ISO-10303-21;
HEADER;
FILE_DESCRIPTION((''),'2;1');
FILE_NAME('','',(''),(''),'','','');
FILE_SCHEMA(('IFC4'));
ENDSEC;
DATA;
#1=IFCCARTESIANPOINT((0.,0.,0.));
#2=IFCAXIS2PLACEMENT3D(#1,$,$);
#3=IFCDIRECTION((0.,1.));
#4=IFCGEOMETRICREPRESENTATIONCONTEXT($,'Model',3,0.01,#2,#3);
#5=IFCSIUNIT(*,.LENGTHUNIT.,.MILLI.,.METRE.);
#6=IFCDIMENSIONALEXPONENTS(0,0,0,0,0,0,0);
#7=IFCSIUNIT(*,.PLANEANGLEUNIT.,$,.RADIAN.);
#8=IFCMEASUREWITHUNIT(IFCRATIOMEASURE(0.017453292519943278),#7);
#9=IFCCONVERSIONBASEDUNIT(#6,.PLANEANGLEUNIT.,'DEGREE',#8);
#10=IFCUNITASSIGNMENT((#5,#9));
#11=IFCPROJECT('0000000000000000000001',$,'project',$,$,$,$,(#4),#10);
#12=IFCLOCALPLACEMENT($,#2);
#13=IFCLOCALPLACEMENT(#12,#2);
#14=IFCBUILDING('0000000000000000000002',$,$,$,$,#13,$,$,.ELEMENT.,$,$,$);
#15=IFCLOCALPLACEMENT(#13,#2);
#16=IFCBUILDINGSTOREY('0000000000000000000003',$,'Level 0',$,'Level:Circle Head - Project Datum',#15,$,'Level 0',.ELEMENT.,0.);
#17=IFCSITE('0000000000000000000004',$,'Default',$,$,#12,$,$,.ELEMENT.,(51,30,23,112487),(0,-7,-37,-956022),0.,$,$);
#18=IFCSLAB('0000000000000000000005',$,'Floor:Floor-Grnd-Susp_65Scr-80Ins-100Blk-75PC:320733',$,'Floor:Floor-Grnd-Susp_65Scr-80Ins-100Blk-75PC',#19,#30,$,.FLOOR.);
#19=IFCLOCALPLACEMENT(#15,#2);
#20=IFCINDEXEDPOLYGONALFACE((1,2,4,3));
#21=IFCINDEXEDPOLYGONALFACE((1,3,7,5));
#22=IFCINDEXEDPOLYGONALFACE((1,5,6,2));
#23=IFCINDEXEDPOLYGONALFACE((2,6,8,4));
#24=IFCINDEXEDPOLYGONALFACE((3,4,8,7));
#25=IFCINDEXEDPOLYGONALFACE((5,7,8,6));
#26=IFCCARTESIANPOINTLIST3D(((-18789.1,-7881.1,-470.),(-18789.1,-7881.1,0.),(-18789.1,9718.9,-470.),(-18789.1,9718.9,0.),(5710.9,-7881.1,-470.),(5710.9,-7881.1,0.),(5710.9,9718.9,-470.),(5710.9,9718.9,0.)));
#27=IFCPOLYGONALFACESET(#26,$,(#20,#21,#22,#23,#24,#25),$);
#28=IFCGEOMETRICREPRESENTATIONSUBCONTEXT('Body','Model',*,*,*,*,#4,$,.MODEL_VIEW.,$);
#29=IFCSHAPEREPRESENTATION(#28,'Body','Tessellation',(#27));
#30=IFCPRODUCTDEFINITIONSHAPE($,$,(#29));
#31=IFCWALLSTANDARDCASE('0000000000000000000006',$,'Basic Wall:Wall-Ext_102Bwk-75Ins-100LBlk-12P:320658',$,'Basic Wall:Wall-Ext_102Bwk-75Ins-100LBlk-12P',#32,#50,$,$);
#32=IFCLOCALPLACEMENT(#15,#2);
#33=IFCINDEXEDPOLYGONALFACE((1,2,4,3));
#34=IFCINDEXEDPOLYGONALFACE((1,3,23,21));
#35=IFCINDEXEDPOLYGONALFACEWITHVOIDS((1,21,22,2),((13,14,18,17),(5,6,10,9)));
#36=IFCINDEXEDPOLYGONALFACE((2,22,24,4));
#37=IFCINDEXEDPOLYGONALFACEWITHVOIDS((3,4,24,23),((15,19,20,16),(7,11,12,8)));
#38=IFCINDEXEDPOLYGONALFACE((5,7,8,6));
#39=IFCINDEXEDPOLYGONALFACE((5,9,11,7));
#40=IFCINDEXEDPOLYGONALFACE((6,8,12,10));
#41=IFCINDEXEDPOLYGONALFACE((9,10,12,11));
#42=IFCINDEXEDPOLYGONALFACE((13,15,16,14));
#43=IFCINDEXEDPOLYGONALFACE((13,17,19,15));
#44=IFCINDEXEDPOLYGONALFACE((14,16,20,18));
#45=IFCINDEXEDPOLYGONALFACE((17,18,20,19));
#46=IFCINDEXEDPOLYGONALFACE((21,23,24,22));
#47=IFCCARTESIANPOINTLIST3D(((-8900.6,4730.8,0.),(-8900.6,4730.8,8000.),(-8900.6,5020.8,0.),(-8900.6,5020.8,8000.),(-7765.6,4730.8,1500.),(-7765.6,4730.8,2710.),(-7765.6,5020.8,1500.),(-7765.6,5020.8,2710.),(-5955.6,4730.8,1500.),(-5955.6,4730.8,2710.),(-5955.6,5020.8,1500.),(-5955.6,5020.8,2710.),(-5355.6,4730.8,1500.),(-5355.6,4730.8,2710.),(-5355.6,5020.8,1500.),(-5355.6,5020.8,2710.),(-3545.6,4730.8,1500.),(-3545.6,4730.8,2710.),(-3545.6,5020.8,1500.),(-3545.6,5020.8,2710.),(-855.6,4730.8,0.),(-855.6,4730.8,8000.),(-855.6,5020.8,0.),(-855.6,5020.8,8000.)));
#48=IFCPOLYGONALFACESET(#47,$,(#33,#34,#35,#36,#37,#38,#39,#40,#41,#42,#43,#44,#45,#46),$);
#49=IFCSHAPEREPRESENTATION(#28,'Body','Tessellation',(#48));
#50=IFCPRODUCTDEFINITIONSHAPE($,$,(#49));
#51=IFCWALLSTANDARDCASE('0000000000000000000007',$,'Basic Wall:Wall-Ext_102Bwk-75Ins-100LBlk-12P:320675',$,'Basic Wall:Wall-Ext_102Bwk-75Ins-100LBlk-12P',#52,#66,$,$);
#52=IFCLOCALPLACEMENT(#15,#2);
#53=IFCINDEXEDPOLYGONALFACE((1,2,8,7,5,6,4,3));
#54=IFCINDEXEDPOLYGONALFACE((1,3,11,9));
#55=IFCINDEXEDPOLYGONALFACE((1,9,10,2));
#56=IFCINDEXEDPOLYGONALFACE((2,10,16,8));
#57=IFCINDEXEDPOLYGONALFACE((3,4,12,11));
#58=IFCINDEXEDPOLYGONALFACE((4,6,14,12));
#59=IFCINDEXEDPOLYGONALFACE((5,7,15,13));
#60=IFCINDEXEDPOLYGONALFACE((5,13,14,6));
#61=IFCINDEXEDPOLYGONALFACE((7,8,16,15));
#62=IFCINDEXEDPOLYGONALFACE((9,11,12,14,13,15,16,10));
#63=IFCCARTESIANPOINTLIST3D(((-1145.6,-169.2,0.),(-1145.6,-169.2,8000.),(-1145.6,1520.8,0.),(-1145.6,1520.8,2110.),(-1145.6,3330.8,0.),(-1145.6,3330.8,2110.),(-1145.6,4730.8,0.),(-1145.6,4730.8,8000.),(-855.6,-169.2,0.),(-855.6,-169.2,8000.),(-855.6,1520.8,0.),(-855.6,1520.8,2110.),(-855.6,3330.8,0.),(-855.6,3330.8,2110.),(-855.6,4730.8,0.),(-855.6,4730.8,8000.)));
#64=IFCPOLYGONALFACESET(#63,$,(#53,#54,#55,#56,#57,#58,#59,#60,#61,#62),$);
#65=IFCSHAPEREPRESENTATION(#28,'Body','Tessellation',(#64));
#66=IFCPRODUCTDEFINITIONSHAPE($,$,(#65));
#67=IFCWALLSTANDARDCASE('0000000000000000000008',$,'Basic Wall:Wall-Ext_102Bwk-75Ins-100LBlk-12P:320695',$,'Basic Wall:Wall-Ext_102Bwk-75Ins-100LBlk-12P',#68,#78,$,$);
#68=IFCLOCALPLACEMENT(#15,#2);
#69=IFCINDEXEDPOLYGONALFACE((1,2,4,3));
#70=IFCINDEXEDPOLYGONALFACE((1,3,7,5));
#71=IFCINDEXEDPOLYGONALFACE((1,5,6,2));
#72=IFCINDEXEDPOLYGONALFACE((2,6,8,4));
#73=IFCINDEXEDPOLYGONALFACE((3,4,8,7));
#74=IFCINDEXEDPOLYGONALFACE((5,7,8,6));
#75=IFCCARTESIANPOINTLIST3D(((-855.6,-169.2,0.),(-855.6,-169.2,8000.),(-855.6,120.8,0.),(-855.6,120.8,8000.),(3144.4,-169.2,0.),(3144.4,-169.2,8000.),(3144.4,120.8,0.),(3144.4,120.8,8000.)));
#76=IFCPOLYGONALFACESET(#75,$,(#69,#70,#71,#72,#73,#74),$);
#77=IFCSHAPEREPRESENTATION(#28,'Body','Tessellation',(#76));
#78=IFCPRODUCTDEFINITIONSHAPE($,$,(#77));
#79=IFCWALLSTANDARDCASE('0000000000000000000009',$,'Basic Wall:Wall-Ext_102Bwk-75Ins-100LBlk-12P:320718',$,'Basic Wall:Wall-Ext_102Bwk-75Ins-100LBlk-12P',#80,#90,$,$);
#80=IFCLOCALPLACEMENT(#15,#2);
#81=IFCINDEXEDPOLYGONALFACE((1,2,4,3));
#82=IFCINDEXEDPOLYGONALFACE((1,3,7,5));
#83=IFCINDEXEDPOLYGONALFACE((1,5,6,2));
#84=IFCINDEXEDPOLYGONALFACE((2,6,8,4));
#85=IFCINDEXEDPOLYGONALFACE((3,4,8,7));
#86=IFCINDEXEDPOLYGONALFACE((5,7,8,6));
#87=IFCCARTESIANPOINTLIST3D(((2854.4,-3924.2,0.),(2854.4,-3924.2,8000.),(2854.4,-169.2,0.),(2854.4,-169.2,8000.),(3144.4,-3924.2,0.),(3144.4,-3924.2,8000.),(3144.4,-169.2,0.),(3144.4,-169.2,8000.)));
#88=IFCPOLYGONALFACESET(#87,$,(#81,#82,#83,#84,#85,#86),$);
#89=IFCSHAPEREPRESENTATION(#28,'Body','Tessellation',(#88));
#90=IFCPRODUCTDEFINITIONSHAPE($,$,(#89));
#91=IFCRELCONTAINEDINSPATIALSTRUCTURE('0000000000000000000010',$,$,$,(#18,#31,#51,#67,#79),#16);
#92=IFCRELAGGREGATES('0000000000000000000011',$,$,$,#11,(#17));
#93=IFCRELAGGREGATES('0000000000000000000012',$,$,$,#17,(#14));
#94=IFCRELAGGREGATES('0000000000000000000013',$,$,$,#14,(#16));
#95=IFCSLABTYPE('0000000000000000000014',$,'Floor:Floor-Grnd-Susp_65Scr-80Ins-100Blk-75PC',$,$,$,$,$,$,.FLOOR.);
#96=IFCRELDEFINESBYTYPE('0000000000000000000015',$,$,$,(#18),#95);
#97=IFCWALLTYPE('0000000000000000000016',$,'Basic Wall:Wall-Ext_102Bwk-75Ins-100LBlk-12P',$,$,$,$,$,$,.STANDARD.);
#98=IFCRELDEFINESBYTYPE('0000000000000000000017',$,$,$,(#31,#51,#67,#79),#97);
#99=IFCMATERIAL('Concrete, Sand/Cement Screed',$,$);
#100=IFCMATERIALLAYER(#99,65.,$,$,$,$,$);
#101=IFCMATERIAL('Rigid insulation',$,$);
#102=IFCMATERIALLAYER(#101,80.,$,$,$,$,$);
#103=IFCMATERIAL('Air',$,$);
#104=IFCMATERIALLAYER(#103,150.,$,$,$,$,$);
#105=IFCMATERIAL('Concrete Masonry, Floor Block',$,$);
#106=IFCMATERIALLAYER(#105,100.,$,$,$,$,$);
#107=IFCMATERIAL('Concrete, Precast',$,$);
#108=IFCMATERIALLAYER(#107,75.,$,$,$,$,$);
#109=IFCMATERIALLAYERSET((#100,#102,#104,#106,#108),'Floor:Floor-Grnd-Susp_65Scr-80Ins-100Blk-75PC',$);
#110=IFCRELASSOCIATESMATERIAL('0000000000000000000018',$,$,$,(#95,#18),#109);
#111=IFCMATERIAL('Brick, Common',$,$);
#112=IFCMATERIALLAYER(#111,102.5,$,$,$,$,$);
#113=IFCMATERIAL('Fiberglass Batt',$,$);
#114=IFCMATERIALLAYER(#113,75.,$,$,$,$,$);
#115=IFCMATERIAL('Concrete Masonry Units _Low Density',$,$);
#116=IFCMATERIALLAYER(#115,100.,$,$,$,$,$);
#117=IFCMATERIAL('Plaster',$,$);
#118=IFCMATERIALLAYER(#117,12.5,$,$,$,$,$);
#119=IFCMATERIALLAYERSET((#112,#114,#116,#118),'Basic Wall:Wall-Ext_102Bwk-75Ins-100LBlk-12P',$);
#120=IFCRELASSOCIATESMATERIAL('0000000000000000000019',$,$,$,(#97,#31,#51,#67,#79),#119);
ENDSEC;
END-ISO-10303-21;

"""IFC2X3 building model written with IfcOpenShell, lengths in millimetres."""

from ifc_helpers import new_model, entity, si_unit, converted_unit, direction, frame, frame_2d, origin, origin_2d_with_axis, place, context, subcontext, project, spatial, rectangle, extrude, material, layer, layer_set, layer_usage, type_object, element, save


model = new_model("IFC2X3")

# Units and contexts
model_context = context("Model", 3, precision=0.01, world=origin(), true_north=direction((0.0, 1.0)))
body_context = subcontext(model_context, "Body", "Model", "MODEL_VIEW")
ifc_project = project(units=[si_unit("LENGTHUNIT", "METRE", prefix="MILLI"), converted_unit("PLANEANGLEUNIT", "DEGREE", entity("IfcRatioMeasure", 0.017453292519943278), si_unit("PLANEANGLEUNIT", "RADIAN"), dimensions=[0, 0, 0, 0, 0, 0, 0])], contexts=[model_context])

# Site, building, storey
site_placement = place(None, origin())
site = spatial("IfcSite", under=ifc_project, at=site_placement, Name="Default", CompositionType="ELEMENT", RefLatitude=(51, 30, 23, 112487), RefLongitude=(0, -7, -37, -956022), RefElevation=0.0)
building_placement = place(site_placement, origin())
building = spatial("IfcBuilding", under=site, at=building_placement, CompositionType="ELEMENT")
storey_placement = place(building_placement, origin())
storey = spatial("IfcBuildingStorey", under=building, at=storey_placement, Name="Level 0", ObjectType="Level:Circle Head - Project Datum", LongName="Level 0", CompositionType="ELEMENT", Elevation=0.0)

# Slab
ifc_material_1 = material(Name="Concrete, Sand/Cement Screed")
ifc_layer_1 = layer(ifc_material_1, 65.0)
ifc_material_2 = material(Name="Rigid insulation")
ifc_layer_2 = layer(ifc_material_2, 80.0)
ifc_material_3 = material(Name="Air")
ifc_layer_3 = layer(ifc_material_3, 150.0)
ifc_material_4 = material(Name="Concrete Masonry, Floor Block")
ifc_layer_4 = layer(ifc_material_4, 100.0)
ifc_material_5 = material(Name="Concrete, Precast")
ifc_layer_5 = layer(ifc_material_5, 75.0)
ifc_layer_set_1 = layer_set([ifc_layer_1, ifc_layer_2, ifc_layer_3, ifc_layer_4, ifc_layer_5], Name="Floor:Floor-Grnd-Susp_65Scr-80Ins-100Blk-75PC")
ifc_layer_usage_1 = layer_usage(ifc_layer_set_1, "AXIS3", "POSITIVE", 0.0)
slab_type = type_object("IfcSlabType", Name="Floor:Floor-Grnd-Susp_65Scr-80Ins-100Blk-75PC", PredefinedType="FLOOR", material=ifc_layer_set_1)
slab_placement = place(storey_placement, origin())
element("IfcSlab", 1, at=slab_placement, inside=storey, type_object=slab_type, material=ifc_layer_usage_1, Name="Floor:Floor-Grnd-Susp_65Scr-80Ins-100Blk-75PC:320733", ObjectType="Floor:Floor-Grnd-Susp_65Scr-80Ins-100Blk-75PC", PredefinedType="FLOOR", context=body_context, shape_type="SweptSolid", body=[
    extrude(rectangle(XDim=17600.0, YDim=24500.0, at=origin_2d_with_axis()), frame((-6539.1, 918.9, 0.0), z_axis=(0.0, 0.0, -1.0), x_axis=(0.0, 1.0, 0.0)), (0.0, 0.0, 1.0), 470.0),
])

# Wall, openings
ifc_material_6 = material(Name="Brick, Common")
ifc_layer_6 = layer(ifc_material_6, 102.5)
ifc_material_7 = material(Name="Fiberglass Batt")
ifc_layer_7 = layer(ifc_material_7, 75.0)
ifc_material_8 = material(Name="Concrete Masonry Units _Low Density")
ifc_layer_8 = layer(ifc_material_8, 100.0)
ifc_material_9 = material(Name="Plaster")
ifc_layer_9 = layer(ifc_material_9, 12.5)
ifc_layer_set_2 = layer_set([ifc_layer_6, ifc_layer_7, ifc_layer_8, ifc_layer_9], Name="Basic Wall:Wall-Ext_102Bwk-75Ins-100LBlk-12P")
ifc_layer_usage_2 = layer_usage(ifc_layer_set_2, "AXIS2", "NEGATIVE", 145.0)
wall_type = type_object("IfcWallType", Name="Basic Wall:Wall-Ext_102Bwk-75Ins-100LBlk-12P", PredefinedType="STANDARD", material=ifc_layer_set_2)
wall_1_placement = place(storey_placement, frame((-8900.6, 4875.8, 0.0)))
wall_1 = element("IfcWallStandardCase", 2, at=wall_1_placement, inside=storey, type_object=wall_type, material=ifc_layer_usage_2, Name="Basic Wall:Wall-Ext_102Bwk-75Ins-100LBlk-12P:320658", ObjectType="Basic Wall:Wall-Ext_102Bwk-75Ins-100LBlk-12P", context=body_context, shape_type="SweptSolid", body=[
    extrude(rectangle(XDim=8045.0, YDim=290.0, at=frame_2d((4022.5, 0.0), x_axis=(-1.0, 0.0))), origin(), (0.0, 0.0, 1.0), 8000.0),
])
opening_1_placement = place(wall_1_placement, frame((3545.0, -145.0, 1500.0)))
element("IfcOpeningElement", 3, at=opening_1_placement, cuts=wall_1, ObjectType="Opening", context=body_context, shape_type="SweptSolid", body=[
    extrude(rectangle(XDim=1210.0, YDim=1810.0, at=frame_2d((605.0, 905.0), x_axis=(-1.0, 0.0))), frame((0.0, 0.0, 0.0), z_axis=(0.0, 1.0, 0.0), x_axis=(0.0, 0.0, 1.0)), (0.0, 0.0, 1.0), 290.0),
])
opening_2_placement = place(wall_1_placement, frame((1135.0, -145.0, 1500.0)))
element("IfcOpeningElement", 4, at=opening_2_placement, cuts=wall_1, ObjectType="Opening", context=body_context, shape_type="SweptSolid", body=[
    extrude(rectangle(XDim=1210.0, YDim=1810.0, at=frame_2d((605.0, 905.0), x_axis=(-1.0, 0.0))), frame((0.0, 0.0, 0.0), z_axis=(0.0, 1.0, 0.0), x_axis=(0.0, 0.0, 1.0)), (0.0, 0.0, 1.0), 290.0),
])

# Wall, opening
ifc_layer_usage_3 = layer_usage(ifc_layer_set_2, "AXIS2", "NEGATIVE", 145.0)
wall_2_placement = place(storey_placement, frame((-1000.6, 4730.8, 0.0), z_axis=(0.0, 0.0, 1.0), x_axis=(0.0, -1.0, 0.0)))
wall_2 = element("IfcWallStandardCase", 5, at=wall_2_placement, inside=storey, type_object=wall_type, material=ifc_layer_usage_3, Name="Basic Wall:Wall-Ext_102Bwk-75Ins-100LBlk-12P:320675", ObjectType="Basic Wall:Wall-Ext_102Bwk-75Ins-100LBlk-12P", context=body_context, shape_type="SweptSolid", body=[
    extrude(rectangle(XDim=4900.0, YDim=290.0, at=frame_2d((2450.0, 0.0), x_axis=(1.0, 0.0))), origin(), (0.0, 0.0, 1.0), 8000.0),
])
opening_3_placement = place(wall_2_placement, frame((1400.0, -145.0, 0.0)))
element("IfcOpeningElement", 6, at=opening_3_placement, cuts=wall_2, ObjectType="Opening", context=body_context, shape_type="SweptSolid", body=[
    extrude(rectangle(XDim=2110.0, YDim=1810.0, at=frame_2d((1055.0, 905.0), x_axis=(-1.0, 0.0))), frame((0.0, 0.0, 0.0), z_axis=(0.0, 1.0, 0.0), x_axis=(0.0, 0.0, 1.0)), (0.0, 0.0, 1.0), 290.0),
])

# Walls
ifc_layer_usage_4 = layer_usage(ifc_layer_set_2, "AXIS2", "NEGATIVE", 145.0)
wall_3_placement = place(storey_placement, frame((-855.6, -24.2, 0.0)))
element("IfcWallStandardCase", 7, at=wall_3_placement, inside=storey, type_object=wall_type, material=ifc_layer_usage_4, Name="Basic Wall:Wall-Ext_102Bwk-75Ins-100LBlk-12P:320695", ObjectType="Basic Wall:Wall-Ext_102Bwk-75Ins-100LBlk-12P", context=body_context, shape_type="SweptSolid", body=[
    extrude(rectangle(XDim=4000.0, YDim=290.0, at=frame_2d((2000.0, 0.0), x_axis=(-1.0, 0.0))), origin(), (0.0, 0.0, 1.0), 8000.0),
])
ifc_layer_usage_5 = layer_usage(ifc_layer_set_2, "AXIS2", "NEGATIVE", 145.0)
wall_4_placement = place(storey_placement, frame((2999.4, -169.2, 0.0), z_axis=(0.0, 0.0, 1.0), x_axis=(0.0, -1.0, 0.0)))
element("IfcWallStandardCase", 8, at=wall_4_placement, inside=storey, type_object=wall_type, material=ifc_layer_usage_5, Name="Basic Wall:Wall-Ext_102Bwk-75Ins-100LBlk-12P:320718", ObjectType="Basic Wall:Wall-Ext_102Bwk-75Ins-100LBlk-12P", context=body_context, shape_type="SweptSolid", body=[
    extrude(rectangle(XDim=3755.0, YDim=290.0, at=frame_2d((1877.5, 0.0), x_axis=(-1.0, 0.0))), origin(), (0.0, 0.0, 1.0), 8000.0),
])

save(model, "model.ifc")
